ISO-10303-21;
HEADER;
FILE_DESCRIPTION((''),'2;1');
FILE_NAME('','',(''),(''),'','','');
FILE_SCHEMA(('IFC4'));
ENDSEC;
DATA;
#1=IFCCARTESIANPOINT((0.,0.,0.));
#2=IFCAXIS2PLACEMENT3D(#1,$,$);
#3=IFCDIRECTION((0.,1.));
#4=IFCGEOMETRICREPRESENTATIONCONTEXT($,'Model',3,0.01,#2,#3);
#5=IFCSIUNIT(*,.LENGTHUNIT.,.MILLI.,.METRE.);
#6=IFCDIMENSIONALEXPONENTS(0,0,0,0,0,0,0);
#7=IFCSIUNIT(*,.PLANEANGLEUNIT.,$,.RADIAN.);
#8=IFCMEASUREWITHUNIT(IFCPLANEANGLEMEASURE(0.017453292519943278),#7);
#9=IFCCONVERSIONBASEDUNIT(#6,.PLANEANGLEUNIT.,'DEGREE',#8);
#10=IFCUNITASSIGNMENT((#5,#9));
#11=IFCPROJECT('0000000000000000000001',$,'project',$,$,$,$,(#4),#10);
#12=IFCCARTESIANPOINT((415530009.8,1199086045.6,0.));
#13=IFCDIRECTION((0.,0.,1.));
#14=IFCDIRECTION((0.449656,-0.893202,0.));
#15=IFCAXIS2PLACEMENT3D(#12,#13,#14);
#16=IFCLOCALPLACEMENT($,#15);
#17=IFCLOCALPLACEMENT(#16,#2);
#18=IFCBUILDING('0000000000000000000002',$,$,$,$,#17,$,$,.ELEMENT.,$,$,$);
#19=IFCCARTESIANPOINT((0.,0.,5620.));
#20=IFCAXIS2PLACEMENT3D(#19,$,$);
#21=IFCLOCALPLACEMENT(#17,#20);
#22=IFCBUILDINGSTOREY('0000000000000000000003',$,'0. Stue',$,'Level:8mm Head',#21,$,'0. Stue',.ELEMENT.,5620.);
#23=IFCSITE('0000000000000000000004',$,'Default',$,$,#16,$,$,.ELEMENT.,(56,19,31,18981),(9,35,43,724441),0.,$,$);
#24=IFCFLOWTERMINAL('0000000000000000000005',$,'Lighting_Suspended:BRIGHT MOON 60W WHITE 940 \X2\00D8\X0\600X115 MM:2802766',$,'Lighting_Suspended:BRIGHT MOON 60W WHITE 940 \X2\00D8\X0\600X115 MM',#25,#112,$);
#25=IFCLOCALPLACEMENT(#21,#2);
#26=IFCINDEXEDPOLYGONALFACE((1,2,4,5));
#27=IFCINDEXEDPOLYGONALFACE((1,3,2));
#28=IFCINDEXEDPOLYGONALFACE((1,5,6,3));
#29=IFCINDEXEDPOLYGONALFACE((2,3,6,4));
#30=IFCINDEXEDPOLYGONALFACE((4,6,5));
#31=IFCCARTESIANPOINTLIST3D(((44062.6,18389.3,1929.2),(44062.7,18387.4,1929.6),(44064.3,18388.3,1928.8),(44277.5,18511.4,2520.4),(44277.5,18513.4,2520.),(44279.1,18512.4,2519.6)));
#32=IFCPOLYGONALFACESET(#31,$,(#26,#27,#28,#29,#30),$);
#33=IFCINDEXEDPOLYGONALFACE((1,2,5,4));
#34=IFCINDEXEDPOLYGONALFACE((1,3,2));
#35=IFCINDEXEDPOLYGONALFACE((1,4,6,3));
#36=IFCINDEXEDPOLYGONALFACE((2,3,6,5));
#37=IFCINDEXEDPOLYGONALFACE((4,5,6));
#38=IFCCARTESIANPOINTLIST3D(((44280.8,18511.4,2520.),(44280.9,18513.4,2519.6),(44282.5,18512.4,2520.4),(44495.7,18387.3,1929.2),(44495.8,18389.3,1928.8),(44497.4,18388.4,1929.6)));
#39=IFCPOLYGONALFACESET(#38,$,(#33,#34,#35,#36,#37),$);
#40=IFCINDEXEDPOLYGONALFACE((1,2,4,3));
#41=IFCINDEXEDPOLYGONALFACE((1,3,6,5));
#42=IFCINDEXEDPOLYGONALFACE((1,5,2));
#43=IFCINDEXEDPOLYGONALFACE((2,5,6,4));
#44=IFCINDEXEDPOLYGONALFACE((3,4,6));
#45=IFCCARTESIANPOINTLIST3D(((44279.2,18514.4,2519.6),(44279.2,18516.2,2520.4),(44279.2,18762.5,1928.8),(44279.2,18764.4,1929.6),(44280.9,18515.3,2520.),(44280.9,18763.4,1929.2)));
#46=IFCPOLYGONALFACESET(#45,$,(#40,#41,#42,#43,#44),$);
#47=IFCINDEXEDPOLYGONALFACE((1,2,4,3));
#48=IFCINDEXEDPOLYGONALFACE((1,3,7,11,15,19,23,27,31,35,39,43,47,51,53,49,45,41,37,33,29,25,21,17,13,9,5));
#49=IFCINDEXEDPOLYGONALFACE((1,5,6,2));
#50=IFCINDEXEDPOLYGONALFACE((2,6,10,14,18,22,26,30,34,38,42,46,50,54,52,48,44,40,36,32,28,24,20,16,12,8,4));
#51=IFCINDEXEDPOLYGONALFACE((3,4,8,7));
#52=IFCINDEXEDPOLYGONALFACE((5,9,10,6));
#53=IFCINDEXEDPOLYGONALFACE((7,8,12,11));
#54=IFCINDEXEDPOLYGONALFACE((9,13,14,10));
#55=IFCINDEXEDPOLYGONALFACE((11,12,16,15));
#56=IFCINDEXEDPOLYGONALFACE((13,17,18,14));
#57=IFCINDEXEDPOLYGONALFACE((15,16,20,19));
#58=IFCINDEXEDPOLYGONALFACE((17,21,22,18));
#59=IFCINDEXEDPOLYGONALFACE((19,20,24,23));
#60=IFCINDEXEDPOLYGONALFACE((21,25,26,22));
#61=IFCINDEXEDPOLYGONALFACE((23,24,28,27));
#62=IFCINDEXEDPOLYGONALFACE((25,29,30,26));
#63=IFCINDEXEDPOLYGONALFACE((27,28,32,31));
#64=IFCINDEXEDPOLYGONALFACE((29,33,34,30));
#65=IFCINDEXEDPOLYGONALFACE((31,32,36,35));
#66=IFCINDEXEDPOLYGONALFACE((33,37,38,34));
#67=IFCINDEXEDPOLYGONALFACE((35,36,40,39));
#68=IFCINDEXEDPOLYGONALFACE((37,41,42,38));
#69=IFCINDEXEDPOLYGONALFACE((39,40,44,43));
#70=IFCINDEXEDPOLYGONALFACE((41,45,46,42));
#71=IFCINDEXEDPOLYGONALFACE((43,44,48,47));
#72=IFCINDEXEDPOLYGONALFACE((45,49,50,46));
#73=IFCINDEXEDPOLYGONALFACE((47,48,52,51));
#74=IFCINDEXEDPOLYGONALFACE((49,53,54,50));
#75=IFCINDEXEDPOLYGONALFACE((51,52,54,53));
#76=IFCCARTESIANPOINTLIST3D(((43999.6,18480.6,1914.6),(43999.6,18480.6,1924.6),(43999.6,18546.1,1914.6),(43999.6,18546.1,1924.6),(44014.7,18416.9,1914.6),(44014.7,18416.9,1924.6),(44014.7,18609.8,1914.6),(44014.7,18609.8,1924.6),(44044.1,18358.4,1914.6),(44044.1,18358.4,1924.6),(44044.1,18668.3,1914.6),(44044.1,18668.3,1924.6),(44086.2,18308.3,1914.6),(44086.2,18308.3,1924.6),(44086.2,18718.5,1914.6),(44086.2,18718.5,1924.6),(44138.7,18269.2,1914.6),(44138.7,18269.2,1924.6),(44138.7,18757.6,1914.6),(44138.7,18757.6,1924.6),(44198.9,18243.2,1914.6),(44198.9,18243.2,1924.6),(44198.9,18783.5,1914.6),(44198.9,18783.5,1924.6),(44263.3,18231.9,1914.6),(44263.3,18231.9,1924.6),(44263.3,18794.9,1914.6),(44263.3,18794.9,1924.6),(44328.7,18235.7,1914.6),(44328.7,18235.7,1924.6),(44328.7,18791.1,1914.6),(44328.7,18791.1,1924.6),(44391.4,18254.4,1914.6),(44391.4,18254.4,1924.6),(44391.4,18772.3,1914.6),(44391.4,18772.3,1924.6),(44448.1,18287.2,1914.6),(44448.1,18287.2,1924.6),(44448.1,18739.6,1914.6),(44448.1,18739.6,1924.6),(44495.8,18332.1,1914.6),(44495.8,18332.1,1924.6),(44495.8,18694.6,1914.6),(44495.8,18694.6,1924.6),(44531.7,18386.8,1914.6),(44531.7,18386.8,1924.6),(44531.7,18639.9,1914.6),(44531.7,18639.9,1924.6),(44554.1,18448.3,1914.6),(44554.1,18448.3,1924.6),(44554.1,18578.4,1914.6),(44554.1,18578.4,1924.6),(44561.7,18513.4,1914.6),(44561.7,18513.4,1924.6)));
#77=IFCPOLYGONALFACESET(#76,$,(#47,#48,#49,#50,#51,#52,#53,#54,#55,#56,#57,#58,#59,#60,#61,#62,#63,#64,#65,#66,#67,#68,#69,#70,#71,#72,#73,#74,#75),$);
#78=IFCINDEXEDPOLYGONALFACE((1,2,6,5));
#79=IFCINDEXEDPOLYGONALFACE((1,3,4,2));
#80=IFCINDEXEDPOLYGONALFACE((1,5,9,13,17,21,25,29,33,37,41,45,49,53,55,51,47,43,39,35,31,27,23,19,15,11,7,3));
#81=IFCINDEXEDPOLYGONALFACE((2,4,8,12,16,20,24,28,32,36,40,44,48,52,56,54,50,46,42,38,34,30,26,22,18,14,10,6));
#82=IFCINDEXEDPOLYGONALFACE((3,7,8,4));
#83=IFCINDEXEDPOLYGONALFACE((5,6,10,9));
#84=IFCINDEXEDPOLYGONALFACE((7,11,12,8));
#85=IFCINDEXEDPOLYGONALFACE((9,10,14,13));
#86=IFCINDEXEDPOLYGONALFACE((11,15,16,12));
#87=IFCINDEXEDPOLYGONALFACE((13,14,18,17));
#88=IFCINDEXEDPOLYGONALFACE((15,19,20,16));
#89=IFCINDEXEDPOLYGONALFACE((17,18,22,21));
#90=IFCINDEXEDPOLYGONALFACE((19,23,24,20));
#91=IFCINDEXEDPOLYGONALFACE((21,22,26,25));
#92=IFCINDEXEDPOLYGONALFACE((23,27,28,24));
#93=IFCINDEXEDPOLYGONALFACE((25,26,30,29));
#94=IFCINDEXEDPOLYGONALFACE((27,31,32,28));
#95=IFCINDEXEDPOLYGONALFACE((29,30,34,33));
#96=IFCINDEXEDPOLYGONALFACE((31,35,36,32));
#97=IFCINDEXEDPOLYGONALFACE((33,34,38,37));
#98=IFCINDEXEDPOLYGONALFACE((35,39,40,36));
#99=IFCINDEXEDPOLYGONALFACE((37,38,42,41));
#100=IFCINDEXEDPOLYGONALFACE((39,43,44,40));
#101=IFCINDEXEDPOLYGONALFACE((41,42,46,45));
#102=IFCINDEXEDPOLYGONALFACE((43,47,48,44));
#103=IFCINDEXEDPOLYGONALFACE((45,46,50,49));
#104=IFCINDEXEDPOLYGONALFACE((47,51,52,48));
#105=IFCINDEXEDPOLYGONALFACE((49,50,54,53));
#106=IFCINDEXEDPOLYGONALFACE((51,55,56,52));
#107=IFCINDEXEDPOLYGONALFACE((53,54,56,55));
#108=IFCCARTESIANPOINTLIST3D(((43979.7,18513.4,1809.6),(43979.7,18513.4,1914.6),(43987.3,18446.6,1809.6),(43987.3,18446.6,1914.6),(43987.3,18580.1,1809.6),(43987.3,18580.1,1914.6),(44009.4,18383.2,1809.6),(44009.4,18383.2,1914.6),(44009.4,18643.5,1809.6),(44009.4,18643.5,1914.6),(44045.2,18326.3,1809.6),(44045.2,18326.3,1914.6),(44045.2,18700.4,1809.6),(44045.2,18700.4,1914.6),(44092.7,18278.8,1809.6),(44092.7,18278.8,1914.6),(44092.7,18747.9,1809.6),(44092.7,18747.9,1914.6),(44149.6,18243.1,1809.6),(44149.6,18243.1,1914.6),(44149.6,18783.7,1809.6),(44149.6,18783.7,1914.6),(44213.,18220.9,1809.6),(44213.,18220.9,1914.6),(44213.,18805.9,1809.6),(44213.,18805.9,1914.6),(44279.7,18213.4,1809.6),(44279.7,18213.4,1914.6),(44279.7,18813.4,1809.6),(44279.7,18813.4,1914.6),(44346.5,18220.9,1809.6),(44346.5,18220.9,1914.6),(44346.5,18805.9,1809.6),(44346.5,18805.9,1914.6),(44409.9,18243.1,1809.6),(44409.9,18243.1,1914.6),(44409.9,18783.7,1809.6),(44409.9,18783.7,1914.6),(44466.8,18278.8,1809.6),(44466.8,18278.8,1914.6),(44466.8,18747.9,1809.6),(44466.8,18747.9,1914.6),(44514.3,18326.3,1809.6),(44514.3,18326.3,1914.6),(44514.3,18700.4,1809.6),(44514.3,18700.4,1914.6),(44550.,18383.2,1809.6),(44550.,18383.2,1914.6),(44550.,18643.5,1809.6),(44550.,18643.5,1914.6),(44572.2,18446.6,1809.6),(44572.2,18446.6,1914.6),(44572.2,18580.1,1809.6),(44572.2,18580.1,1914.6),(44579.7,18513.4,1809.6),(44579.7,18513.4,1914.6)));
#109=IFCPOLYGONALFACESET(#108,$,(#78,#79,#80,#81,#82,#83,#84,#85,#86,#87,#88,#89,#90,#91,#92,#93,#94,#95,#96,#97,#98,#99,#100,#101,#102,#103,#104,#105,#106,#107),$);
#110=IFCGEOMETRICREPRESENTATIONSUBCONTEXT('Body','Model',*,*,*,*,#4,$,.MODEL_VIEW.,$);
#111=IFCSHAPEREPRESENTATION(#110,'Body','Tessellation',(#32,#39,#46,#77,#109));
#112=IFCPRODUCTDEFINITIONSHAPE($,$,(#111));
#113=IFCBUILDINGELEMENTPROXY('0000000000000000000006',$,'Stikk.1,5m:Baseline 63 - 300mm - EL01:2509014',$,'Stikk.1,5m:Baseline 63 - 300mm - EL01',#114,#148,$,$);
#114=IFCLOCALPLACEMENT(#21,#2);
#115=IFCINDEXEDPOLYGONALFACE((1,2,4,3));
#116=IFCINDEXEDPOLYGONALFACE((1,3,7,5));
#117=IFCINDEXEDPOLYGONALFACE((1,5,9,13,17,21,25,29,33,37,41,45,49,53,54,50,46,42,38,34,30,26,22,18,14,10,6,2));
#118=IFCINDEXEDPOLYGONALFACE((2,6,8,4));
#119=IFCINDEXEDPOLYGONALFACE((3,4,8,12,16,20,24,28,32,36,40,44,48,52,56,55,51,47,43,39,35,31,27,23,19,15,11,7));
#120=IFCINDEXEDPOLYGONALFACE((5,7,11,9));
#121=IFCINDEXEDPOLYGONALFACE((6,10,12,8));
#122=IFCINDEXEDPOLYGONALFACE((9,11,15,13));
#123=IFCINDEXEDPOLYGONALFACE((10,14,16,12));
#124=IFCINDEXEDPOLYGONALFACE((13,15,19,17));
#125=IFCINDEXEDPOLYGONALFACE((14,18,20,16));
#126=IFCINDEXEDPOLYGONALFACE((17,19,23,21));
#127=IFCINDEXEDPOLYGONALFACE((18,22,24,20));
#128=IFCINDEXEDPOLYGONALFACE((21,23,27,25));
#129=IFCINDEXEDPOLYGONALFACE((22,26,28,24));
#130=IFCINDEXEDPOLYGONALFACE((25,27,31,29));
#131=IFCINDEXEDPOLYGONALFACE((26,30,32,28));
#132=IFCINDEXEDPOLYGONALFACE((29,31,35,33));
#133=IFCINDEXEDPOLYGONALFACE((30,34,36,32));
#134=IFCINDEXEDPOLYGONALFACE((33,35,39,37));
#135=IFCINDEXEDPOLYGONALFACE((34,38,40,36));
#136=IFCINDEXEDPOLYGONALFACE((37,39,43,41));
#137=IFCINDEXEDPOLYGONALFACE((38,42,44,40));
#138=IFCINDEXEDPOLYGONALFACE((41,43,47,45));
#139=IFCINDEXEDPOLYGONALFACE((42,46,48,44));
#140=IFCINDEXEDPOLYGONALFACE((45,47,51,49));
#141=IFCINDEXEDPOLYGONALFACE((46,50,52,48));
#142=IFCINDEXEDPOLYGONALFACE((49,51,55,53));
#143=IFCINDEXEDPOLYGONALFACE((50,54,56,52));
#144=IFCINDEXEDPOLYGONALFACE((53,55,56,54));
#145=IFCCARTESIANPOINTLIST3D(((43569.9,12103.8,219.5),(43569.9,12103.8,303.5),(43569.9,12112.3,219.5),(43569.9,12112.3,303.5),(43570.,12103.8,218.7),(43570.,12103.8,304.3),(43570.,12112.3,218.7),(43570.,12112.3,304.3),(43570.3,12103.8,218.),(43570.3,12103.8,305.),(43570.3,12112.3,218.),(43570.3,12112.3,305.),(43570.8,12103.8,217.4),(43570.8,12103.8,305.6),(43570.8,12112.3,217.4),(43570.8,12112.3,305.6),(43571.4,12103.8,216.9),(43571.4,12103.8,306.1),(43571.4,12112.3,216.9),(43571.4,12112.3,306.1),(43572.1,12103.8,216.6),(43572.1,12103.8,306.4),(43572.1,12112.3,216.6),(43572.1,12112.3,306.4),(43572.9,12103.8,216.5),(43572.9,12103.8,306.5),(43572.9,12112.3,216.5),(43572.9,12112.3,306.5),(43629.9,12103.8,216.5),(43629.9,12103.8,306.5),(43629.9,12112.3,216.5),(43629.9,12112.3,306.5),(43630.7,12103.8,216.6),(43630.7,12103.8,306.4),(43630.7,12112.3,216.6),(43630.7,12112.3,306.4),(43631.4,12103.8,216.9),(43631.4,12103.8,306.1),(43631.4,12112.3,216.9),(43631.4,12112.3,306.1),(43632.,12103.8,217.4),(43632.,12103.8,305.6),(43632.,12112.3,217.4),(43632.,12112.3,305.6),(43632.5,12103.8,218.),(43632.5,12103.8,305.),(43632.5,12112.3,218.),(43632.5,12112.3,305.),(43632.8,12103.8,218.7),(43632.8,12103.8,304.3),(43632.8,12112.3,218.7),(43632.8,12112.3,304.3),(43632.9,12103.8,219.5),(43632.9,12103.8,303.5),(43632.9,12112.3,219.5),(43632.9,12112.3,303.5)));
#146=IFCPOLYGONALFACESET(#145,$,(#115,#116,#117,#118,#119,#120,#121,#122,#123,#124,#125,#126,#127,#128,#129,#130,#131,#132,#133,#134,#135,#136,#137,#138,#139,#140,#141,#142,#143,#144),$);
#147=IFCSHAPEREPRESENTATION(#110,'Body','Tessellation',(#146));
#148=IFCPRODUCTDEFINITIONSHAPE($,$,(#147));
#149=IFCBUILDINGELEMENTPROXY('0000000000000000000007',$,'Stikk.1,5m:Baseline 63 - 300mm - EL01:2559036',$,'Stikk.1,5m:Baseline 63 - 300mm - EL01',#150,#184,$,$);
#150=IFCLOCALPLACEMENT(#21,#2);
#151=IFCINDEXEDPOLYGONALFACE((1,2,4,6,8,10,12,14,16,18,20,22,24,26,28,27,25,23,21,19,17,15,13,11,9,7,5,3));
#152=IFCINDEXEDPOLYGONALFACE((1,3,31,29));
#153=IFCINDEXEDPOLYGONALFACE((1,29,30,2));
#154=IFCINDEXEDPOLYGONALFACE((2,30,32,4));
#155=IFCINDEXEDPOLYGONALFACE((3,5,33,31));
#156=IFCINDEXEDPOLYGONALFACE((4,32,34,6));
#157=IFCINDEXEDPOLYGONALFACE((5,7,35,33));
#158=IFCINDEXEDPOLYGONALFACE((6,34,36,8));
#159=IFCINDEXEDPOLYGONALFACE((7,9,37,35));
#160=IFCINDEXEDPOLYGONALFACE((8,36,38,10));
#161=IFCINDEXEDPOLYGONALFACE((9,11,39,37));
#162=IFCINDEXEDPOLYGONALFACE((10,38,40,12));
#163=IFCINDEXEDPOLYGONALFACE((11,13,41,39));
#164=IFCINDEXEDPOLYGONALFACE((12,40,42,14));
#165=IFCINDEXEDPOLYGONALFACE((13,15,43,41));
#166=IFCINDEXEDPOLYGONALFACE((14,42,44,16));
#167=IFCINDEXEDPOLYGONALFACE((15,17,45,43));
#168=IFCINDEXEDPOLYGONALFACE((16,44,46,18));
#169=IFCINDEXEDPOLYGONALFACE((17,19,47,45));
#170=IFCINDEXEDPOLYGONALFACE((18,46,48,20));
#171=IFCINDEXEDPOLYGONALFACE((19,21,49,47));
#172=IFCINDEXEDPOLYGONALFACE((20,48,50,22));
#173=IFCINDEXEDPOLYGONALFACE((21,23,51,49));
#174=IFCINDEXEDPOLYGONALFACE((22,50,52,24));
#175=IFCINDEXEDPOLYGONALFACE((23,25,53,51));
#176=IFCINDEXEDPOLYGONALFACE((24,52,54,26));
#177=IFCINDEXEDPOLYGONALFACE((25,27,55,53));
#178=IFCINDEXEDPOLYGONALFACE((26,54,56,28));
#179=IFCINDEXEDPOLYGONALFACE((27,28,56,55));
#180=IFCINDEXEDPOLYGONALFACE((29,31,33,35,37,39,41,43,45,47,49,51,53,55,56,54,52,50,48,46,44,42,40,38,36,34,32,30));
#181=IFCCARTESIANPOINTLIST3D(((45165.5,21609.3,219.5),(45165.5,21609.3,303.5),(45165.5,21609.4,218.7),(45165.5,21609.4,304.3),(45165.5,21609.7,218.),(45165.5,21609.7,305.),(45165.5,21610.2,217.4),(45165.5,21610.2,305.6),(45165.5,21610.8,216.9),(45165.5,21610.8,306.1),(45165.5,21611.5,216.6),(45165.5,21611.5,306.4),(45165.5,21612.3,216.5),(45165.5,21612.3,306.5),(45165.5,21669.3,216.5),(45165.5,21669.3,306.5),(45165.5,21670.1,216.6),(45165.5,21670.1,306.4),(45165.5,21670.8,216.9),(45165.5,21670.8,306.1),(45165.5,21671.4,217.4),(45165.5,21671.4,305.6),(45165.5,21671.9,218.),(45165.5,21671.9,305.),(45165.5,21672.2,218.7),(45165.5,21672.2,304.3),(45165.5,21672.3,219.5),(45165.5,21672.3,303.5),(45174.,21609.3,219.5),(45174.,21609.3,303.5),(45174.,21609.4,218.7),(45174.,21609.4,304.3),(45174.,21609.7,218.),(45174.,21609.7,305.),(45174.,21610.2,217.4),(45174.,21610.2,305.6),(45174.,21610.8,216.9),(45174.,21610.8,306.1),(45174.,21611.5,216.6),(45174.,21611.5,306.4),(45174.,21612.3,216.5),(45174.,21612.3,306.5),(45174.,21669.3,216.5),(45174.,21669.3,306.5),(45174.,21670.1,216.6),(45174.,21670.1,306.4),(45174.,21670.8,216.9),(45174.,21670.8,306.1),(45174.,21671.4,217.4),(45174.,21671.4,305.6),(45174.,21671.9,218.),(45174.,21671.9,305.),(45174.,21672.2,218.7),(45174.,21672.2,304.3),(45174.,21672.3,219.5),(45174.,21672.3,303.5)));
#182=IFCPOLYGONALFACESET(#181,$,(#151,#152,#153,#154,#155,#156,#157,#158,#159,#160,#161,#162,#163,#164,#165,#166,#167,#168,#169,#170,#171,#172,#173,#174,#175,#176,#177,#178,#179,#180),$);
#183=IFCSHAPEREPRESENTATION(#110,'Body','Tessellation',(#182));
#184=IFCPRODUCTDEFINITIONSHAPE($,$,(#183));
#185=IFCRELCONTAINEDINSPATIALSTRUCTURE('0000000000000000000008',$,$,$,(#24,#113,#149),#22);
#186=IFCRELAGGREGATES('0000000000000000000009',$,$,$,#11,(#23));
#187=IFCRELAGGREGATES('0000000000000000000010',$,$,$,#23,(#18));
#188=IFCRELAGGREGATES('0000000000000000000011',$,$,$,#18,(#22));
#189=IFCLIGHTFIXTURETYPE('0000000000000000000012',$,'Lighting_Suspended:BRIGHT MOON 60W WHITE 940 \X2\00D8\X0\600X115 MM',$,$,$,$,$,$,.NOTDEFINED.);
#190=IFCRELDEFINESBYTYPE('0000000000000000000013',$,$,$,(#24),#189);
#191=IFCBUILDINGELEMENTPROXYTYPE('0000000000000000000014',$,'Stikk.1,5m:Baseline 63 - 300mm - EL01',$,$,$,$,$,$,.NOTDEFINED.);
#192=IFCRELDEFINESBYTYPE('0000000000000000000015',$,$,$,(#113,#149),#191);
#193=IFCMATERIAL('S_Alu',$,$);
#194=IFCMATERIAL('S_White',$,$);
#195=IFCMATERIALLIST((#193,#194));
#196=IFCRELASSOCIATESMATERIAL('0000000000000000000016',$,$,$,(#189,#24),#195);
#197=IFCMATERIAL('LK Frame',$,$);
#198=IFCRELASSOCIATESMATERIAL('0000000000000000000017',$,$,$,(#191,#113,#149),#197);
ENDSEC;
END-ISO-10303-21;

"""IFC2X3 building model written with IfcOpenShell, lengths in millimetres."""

from ifc_helpers import new_model, entity, si_unit, converted_unit, direction, frame, frame_2d, origin, place, context, subcontext, project, spatial, polyline, circle_curve, parameter, trimmed, segment, composite_curve, circle, outline, extrude, source, transform, mapped, material, material_list, type_object, type_shapes, element, save


model = new_model("IFC2X3")

# Units and contexts
model_context = context("Model", 3, precision=0.01, world=origin(), true_north=direction((0.0, 1.0)))
body_context = subcontext(model_context, "Body", "Model", "MODEL_VIEW")
ifc_project = project(units=[si_unit("LENGTHUNIT", "METRE", prefix="MILLI"), converted_unit("PLANEANGLEUNIT", "DEGREE", entity("IfcPlaneAngleMeasure", 0.017453292519943278), si_unit("PLANEANGLEUNIT", "RADIAN"), dimensions=[0, 0, 0, 0, 0, 0, 0])], contexts=[model_context])

# Site, building, storey
site_placement = place(None, frame((415530009.8, 1199086045.6, 0.0), z_axis=(0.0, 0.0, 1.0), x_axis=(0.449656, -0.893202, 0.0)))
site = spatial("IfcSite", under=ifc_project, at=site_placement, Name="Default", CompositionType="ELEMENT", RefLatitude=(56, 19, 31, 18981), RefLongitude=(9, 35, 43, 724441), RefElevation=0.0)
building_placement = place(site_placement, origin())
building = spatial("IfcBuilding", under=site, at=building_placement, CompositionType="ELEMENT")
storey_placement = place(building_placement, frame((0.0, 0.0, 5620.0)))
storey = spatial("IfcBuildingStorey", under=building, at=storey_placement, Name="0. Stue", ObjectType="Level:8mm Head", LongName="0. Stue", CompositionType="ELEMENT", Elevation=5620.0)

# Flow terminal
ifc_material_1 = material(Name="S_Alu")
ifc_material_2 = material(Name="S_White")
ifc_material_list = material_list([ifc_material_1, ifc_material_2])
light_fixture_type_1 = type_object("IfcLightFixtureType", Name="Lighting_Suspended:BRIGHT MOON 60W WHITE 940 Ø600X115 MM", PredefinedType="NOTDEFINED", material=ifc_material_list)
shared_shape_1 = source(origin(), body_context, "Body", "SweptSolid", [
    extrude(outline(polyline([(-1.0, -0.6), (1.0, -0.6), (0.0, 1.2), (-1.0, -0.6)])), frame((-216.6, -125.0, -595.4), z_axis=(0.335353, 0.193616, 0.921982), x_axis=(-0.832243, 0.519504, 0.193616)), (0.0, 0.0, 1.0), 640.8),
    extrude(outline(polyline([(-1.0, -0.6), (1.0, -0.6), (0.0, 1.2), (-1.0, -0.6)])), frame((216.6, -125.0, -595.4), z_axis=(-0.335353, 0.193616, 0.921982), x_axis=(-0.033783, -0.980496, 0.193616)), (0.0, 0.0, 1.0), 640.8),
    extrude(outline(polyline([(-1.0, -0.6), (1.0, -0.6), (0.0, 1.2), (-1.0, -0.6)])), frame((0.0, 250.1, -595.4), z_axis=(0.0, -0.387232, 0.921982), x_axis=(0.866025, 0.460991, 0.193616)), (0.0, 0.0, 1.0), 640.8),
    extrude(circle(Radius=282.0, at=frame_2d((0.0, 0.0), x_axis=(1.0, 0.0))), frame((0.0, 0.0, -610.0)), (0.0, 0.0, 1.0), 10.0),
    extrude(circle(Radius=300.0, at=frame_2d((0.0, 0.0), x_axis=(1.0, 0.0))), frame((0.0, 0.0, -715.0)), (0.0, 0.0, 1.0), 105.0),
])
type_shapes(light_fixture_type_1, [shared_shape_1])
for number, where, name in (
    (1, (44279.7, 18513.4, 2524.6), "Lighting_Suspended:BRIGHT MOON 60W WHITE 940 Ø600X115 MM:2802766"),
):
    element("IfcFlowTerminal", number, at=place(storey_placement, frame(where)), inside=storey, type_object=light_fixture_type_1, material=ifc_material_list, Name=name, ObjectType="Lighting_Suspended:BRIGHT MOON 60W WHITE 940 Ø600X115 MM", context=body_context, shape_type="MappedRepresentation", body=[
        mapped(shared_shape_1, transform((0.0, 0.0, 0.0), scale=1.0)),
    ])

# Building element proxies
ifc_material_3 = material(Name="LK Frame")
building_element_proxy_type_1 = type_object("IfcBuildingElementProxyType", Name="Stikk.1,5m:Baseline 63 - 300mm - EL01", PredefinedType="NOTDEFINED", material=ifc_material_3)
shared_shape_2 = source(origin(), body_context, "Body", "SweptSolid", [
    extrude(outline(composite_curve([segment(polyline([(-42.0, -31.5), (42.0, -31.5)]), True, "CONTINUOUS"), segment(trimmed(circle_curve(frame_2d((42.0, -28.5), x_axis=(-1.0, 0.0)), 3.0), [parameter(90.0)], [parameter(180.0)], True, "PARAMETER"), True, "CONTINUOUS"), segment(polyline([(45.0, -28.5), (45.0, 28.5)]), True, "CONTINUOUS"), segment(trimmed(circle_curve(frame_2d((42.0, 28.5), x_axis=(-1.0, 0.0)), 3.0), [parameter(180.0)], [parameter(270.0)], True, "PARAMETER"), True, "CONTINUOUS"), segment(polyline([(42.0, 31.5), (-42.0, 31.5)]), True, "CONTINUOUS"), segment(trimmed(circle_curve(frame_2d((-42.0, 28.5), x_axis=(1.0, 0.0)), 3.0), [parameter(90.0)], [parameter(180.0)], True, "PARAMETER"), True, "CONTINUOUS"), segment(polyline([(-45.0, 28.5), (-45.0, -28.5)]), True, "CONTINUOUS"), segment(trimmed(circle_curve(frame_2d((-42.0, -28.5), x_axis=(1.0, 0.0)), 3.0), [parameter(180.0)], [parameter(270.0)], True, "PARAMETER"), True, "CONTINUOUS")], self_intersect=False)), frame((0.0, -38.5, 0.0), z_axis=(0.0, 0.0, 1.0), x_axis=(0.0, 1.0, 0.0)), (0.0, 0.0, 1.0), 8.5),
])
type_shapes(building_element_proxy_type_1, [shared_shape_2])
for number, where, z_axis, x_axis, name in (
    (2, (43601.4, 12103.8, 300.0), (0.0, 1.0, 0.0), (-1.0, 0.0, 0.0), "Stikk.1,5m:Baseline 63 - 300mm - EL01:2509014"),
    (3, (45174.0, 21640.8, 300.0), (-1.0, 0.0, 0.0), (0.0, -1.0, 0.0), "Stikk.1,5m:Baseline 63 - 300mm - EL01:2559036"),
):
    element("IfcBuildingElementProxy", number, at=place(storey_placement, frame(where, z_axis=z_axis, x_axis=x_axis)), inside=storey, type_object=building_element_proxy_type_1, material=ifc_material_3, Name=name, ObjectType="Stikk.1,5m:Baseline 63 - 300mm - EL01", context=body_context, shape_type="MappedRepresentation", body=[
        mapped(shared_shape_2, transform((0.0, 0.0, 0.0), scale=1.0)),
    ])

save(model, "model.ifc")
